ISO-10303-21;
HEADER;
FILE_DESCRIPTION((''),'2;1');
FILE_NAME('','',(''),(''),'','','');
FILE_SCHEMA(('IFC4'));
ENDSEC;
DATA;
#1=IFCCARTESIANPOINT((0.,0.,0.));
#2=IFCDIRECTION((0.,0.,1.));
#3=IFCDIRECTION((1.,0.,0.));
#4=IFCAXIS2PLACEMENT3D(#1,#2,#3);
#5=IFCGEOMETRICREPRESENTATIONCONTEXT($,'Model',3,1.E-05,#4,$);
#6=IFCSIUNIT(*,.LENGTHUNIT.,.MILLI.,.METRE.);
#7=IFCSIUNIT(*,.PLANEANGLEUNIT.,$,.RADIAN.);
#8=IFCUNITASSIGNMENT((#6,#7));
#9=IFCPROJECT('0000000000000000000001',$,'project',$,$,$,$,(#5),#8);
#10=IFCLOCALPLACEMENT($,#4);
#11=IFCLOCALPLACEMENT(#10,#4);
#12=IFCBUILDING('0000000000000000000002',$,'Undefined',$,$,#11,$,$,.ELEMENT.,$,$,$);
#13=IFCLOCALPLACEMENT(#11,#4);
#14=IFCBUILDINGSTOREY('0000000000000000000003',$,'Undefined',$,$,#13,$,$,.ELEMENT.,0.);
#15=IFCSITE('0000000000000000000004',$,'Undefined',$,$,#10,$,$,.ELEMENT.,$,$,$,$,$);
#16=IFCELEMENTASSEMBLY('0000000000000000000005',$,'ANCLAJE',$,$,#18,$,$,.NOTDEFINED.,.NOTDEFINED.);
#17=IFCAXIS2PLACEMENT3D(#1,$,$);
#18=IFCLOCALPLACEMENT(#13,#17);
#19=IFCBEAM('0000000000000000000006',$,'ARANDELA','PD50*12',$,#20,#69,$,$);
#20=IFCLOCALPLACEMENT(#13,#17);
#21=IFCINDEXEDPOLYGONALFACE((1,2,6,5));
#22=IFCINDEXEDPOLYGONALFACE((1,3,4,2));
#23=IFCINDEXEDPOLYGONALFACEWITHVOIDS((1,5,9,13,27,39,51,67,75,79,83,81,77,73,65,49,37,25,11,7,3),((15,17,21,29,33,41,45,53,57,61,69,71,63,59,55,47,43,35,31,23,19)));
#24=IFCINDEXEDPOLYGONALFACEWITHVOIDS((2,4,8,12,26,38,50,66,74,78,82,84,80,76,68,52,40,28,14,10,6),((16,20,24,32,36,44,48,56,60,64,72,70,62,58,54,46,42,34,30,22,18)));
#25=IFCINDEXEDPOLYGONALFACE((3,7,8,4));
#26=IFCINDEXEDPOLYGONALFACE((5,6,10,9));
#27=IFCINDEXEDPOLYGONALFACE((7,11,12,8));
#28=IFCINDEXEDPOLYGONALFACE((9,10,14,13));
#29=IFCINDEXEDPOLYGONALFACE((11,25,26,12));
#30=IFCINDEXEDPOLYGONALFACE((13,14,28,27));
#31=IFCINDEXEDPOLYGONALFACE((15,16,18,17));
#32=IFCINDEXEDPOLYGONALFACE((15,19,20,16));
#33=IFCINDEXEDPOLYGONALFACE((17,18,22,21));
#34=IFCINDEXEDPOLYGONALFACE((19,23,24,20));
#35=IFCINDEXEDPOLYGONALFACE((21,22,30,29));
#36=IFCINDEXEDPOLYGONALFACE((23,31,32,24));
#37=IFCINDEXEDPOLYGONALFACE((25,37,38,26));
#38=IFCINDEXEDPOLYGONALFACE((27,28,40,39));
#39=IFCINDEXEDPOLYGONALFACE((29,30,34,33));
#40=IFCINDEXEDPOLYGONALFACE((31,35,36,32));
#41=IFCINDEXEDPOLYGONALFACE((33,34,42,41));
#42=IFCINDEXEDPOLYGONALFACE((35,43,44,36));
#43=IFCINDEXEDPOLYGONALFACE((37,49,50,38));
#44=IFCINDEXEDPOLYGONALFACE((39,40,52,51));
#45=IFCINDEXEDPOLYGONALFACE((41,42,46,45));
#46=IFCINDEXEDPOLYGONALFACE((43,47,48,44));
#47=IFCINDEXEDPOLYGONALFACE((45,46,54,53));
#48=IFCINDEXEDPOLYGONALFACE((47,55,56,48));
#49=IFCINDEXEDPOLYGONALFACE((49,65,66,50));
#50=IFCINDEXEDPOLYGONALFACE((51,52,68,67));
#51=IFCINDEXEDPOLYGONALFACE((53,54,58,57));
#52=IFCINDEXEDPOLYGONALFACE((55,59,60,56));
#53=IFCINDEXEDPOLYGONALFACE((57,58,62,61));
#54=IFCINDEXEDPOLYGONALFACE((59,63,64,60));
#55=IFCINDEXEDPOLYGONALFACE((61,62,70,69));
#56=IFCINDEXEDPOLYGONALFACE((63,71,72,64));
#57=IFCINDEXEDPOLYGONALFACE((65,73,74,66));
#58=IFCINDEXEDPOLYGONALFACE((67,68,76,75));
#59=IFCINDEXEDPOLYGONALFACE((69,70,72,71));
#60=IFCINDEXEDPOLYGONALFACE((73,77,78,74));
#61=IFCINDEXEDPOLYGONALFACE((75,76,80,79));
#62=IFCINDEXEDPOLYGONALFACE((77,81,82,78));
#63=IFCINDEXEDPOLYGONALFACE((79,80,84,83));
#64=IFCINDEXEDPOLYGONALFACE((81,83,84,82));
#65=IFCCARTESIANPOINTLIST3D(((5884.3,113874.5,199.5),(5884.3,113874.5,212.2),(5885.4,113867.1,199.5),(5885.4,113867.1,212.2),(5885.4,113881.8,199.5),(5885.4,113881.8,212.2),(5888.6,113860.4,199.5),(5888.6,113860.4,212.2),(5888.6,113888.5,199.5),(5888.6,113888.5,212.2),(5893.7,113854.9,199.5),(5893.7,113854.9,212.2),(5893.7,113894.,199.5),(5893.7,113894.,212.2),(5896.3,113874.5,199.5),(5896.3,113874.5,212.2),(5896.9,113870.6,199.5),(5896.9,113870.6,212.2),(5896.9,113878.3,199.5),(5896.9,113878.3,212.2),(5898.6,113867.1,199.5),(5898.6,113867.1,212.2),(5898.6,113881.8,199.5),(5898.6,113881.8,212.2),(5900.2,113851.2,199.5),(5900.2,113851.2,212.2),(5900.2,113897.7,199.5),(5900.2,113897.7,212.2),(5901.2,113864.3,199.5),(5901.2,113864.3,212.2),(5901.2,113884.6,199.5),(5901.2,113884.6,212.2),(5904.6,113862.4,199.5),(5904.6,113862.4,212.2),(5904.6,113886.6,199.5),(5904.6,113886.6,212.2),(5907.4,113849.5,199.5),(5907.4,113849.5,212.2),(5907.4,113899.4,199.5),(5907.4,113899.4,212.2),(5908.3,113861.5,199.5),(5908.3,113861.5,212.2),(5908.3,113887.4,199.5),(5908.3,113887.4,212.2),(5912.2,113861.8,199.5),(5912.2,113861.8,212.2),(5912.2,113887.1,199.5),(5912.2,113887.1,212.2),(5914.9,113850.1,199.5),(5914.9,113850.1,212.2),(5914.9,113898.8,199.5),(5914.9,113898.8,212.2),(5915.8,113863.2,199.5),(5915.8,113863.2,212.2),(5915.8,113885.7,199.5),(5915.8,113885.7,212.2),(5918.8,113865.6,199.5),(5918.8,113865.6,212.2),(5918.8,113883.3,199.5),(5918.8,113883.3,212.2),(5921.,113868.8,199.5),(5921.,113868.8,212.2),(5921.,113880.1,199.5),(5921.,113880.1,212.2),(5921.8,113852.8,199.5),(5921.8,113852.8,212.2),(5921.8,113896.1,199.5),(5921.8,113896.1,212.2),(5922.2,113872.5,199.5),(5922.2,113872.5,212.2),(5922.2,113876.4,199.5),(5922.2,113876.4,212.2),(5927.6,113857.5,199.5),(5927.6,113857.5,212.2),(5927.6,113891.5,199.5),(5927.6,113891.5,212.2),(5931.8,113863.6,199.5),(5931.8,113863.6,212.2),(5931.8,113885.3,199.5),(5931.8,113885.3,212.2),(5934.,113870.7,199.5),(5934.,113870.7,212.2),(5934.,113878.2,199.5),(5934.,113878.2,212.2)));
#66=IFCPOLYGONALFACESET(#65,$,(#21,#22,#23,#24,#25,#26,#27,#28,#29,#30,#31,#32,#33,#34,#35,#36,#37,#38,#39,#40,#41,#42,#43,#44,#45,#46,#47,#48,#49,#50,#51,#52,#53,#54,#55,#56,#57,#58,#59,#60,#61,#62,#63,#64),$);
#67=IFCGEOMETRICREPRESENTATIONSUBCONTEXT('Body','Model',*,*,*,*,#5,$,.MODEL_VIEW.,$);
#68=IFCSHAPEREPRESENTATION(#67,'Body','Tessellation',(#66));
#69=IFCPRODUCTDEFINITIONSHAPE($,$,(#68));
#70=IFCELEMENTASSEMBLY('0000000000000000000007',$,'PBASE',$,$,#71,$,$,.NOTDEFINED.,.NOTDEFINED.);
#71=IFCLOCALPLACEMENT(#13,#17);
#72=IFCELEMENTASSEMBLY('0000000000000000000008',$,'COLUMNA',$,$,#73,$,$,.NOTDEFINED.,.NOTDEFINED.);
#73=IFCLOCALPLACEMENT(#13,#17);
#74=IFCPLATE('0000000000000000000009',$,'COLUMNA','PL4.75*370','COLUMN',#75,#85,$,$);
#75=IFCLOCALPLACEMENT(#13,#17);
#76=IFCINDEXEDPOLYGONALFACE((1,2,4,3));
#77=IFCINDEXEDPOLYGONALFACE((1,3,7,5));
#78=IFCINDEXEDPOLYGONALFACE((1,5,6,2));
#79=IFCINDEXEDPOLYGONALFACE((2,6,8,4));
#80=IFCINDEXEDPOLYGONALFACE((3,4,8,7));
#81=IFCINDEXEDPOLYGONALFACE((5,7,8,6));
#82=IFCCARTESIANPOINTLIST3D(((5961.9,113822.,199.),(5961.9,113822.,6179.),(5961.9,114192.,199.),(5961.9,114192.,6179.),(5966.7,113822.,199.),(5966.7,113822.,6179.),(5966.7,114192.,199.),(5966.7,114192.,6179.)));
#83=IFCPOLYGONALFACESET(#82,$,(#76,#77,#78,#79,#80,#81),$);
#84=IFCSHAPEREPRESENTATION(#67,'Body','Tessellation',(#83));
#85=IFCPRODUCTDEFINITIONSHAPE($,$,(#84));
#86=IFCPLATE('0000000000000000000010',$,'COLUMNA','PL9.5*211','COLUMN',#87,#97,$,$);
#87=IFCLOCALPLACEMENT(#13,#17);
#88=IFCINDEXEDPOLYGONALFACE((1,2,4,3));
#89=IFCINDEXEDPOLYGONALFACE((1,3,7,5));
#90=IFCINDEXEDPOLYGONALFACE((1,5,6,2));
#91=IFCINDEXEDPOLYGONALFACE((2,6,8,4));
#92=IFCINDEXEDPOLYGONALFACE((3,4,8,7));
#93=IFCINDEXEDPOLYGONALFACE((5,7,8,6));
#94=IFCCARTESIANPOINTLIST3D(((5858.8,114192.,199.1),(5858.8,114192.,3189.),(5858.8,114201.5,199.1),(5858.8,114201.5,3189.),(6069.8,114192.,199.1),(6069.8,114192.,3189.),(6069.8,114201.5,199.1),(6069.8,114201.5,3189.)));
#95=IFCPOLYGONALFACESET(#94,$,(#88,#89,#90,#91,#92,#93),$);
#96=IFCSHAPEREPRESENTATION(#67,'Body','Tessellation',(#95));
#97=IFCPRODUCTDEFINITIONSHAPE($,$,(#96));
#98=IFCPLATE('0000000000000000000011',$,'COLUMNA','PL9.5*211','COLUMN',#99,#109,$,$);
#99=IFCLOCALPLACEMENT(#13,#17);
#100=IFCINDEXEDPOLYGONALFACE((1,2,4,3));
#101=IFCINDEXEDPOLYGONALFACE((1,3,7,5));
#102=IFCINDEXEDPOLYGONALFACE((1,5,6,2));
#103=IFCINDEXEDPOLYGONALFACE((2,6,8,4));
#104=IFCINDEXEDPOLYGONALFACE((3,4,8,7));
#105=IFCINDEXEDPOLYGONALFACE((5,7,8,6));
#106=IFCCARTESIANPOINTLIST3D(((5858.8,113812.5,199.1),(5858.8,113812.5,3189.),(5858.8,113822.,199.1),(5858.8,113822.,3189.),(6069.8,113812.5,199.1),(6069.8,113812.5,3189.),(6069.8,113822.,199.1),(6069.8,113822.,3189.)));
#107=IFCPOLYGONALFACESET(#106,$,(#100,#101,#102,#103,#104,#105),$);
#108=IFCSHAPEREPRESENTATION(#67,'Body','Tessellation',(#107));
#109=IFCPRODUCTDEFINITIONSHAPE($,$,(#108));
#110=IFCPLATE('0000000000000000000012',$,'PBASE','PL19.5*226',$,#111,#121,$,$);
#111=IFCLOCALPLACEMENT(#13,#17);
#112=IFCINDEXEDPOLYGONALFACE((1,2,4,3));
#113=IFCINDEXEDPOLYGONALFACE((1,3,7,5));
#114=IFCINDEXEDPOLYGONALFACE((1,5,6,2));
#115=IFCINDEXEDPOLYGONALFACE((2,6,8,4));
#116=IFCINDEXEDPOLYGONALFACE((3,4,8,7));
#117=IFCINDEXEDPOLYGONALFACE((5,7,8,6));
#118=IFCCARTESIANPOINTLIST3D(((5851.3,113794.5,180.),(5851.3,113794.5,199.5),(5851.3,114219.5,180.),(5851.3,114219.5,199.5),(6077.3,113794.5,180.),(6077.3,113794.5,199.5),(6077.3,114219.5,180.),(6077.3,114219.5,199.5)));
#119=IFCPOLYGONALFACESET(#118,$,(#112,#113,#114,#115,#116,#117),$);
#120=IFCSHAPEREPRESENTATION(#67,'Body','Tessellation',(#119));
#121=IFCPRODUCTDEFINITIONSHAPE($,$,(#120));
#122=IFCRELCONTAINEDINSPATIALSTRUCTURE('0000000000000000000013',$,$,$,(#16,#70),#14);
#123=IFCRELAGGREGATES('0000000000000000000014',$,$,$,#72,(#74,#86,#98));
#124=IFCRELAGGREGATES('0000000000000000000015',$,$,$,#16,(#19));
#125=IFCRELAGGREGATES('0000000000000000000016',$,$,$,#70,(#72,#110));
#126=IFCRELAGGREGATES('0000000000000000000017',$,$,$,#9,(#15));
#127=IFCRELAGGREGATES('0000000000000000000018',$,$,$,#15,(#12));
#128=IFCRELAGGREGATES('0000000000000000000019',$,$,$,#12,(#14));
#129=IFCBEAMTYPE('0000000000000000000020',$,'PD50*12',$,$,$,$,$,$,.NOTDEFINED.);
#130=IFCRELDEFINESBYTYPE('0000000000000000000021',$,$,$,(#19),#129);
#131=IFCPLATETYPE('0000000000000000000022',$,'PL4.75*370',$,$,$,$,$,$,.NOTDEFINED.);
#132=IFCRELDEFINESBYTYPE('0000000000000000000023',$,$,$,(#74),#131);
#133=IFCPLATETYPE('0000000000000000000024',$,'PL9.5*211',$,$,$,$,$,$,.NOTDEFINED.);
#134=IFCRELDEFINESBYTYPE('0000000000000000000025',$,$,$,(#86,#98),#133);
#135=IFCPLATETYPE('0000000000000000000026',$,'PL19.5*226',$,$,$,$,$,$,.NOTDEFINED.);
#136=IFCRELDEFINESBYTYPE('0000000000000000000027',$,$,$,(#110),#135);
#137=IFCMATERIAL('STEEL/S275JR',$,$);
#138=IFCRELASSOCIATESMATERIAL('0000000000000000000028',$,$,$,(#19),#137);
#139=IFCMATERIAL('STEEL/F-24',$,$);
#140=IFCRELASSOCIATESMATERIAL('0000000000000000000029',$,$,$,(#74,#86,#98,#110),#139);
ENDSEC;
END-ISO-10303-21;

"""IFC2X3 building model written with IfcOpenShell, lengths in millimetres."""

from ifc_helpers import new_model, si_unit, frame, origin_with_axes, origin_2d_with_axis, place, context, subcontext, project, spatial, polyline, hollow_circle, outline, extrude, material, type_object, element, aggregate, save


model = new_model("IFC2X3")

# Units and contexts
model_context = context("Model", 3, precision=1e-05, world=origin_with_axes())
body_context = subcontext(model_context, "Body", "Model", "MODEL_VIEW")
ifc_project = project(units=[si_unit("LENGTHUNIT", "METRE", prefix="MILLI"), si_unit("PLANEANGLEUNIT", "RADIAN")], contexts=[model_context])

# Site, building, storey
site_placement = place(None, origin_with_axes())
site = spatial("IfcSite", under=ifc_project, at=site_placement, Name="Undefined", CompositionType="ELEMENT")
building_placement = place(site_placement, origin_with_axes())
building = spatial("IfcBuilding", under=site, at=building_placement, Name="Undefined", CompositionType="ELEMENT")
storey_placement = place(building_placement, origin_with_axes())
storey = spatial("IfcBuildingStorey", under=building, at=storey_placement, Name="Undefined", CompositionType="ELEMENT", Elevation=0.0)

# Shared definitions
ifc_material_1 = material(Name="STEEL/F-24")

# Element assembly, beam
assembly_1_placement = place(storey_placement, origin_with_axes())
assembly_1 = element("IfcElementAssembly", 1, at=assembly_1_placement, inside=storey, Name="ANCLAJE", AssemblyPlace="NOTDEFINED", PredefinedType="NOTDEFINED")
ifc_material_2 = material(Name="STEEL/S275JR")
beam_type_1 = type_object("IfcBeamType", Name="PD50*12", PredefinedType="NOTDEFINED")
beam_1_placement = place(assembly_1_placement, frame((5909.3, 113874.5, 212.2), z_axis=(0.0, -1.0, 0.0), x_axis=(0.0, 0.0, -1.0)))
beam_1 = element("IfcBeam", 2, at=beam_1_placement, type_object=beam_type_1, material=ifc_material_2, Name="ARANDELA", Description="PD50*12", context=body_context, shape_type="SweptSolid", body=[
    extrude(hollow_circle(Radius=25.0, WallThickness=12.0, at=origin_2d_with_axis()), frame((12.7, 0.0, 0.0), z_axis=(-1.0, 0.0, 0.0), x_axis=(0.0, -1.0, 0.0)), (0.0, 0.0, 1.0), 12.7),
])

# Element assemblies, plates
assembly_2_placement = place(storey_placement, origin_with_axes())
assembly_2 = element("IfcElementAssembly", 3, at=assembly_2_placement, inside=storey, Name="PBASE", AssemblyPlace="NOTDEFINED", PredefinedType="NOTDEFINED")
assembly_3_placement = place(assembly_2_placement, origin_with_axes())
assembly_3 = element("IfcElementAssembly", 4, at=assembly_3_placement, Name="COLUMNA", AssemblyPlace="NOTDEFINED", PredefinedType="NOTDEFINED")
plate_type_1 = type_object("IfcPlateType", Name="PL4.75*370", PredefinedType="NOTDEFINED")
plate_1_placement = place(assembly_3_placement, frame((5964.3, 114007.0, 199.1), z_axis=(-1.0, 0.0, 0.0), x_axis=(0.0, 0.0, 1.0)))
plate_1 = element("IfcPlate", 5, at=plate_1_placement, type_object=plate_type_1, material=ifc_material_1, Name="COLUMNA", Description="PL4.75*370", ObjectType="COLUMN", context=body_context, shape_type="SweptSolid", body=[
    extrude(outline(polyline([(0.0, -185.0), (0.0, 185.0), (5980.0, 185.0), (5980.0, -185.0), (0.0, -185.0)])), frame((0.0, 0.0, -2.4), z_axis=(0.0, 0.0, 1.0), x_axis=(1.0, 0.0, 0.0)), (0.0, 0.0, 1.0), 4.8),
])
plate_type_2 = type_object("IfcPlateType", Name="PL9.5*211", PredefinedType="NOTDEFINED")
plate_2_placement = place(assembly_3_placement, frame((5964.3, 114196.7, 199.1), z_axis=(0.0, -1.0, 0.0), x_axis=(0.0, 0.0, 1.0)))
plate_2 = element("IfcPlate", 6, at=plate_2_placement, type_object=plate_type_2, material=ifc_material_1, Name="COLUMNA", Description="PL9.5*211", ObjectType="COLUMN", context=body_context, shape_type="SweptSolid", body=[
    extrude(outline(polyline([(0.0, -105.5), (0.0, 105.5), (2990.0, 105.5), (2990.0, -105.5), (0.0, -105.5)])), frame((0.0, 0.0, -4.8), z_axis=(0.0, 0.0, 1.0), x_axis=(1.0, 0.0, 0.0)), (0.0, 0.0, 1.0), 9.5),
])
plate_3_placement = place(assembly_3_placement, frame((5964.3, 113817.2, 199.1), z_axis=(0.0, -1.0, 0.0), x_axis=(0.0, 0.0, 1.0)))
plate_3 = element("IfcPlate", 7, at=plate_3_placement, type_object=plate_type_2, material=ifc_material_1, Name="COLUMNA", Description="PL9.5*211", ObjectType="COLUMN", context=body_context, shape_type="SweptSolid", body=[
    extrude(outline(polyline([(0.0, -105.5), (0.0, 105.5), (2990.0, 105.5), (2990.0, -105.5), (0.0, -105.5)])), frame((0.0, 0.0, -4.8), z_axis=(0.0, 0.0, 1.0), x_axis=(1.0, 0.0, 0.0)), (0.0, 0.0, 1.0), 9.5),
])
aggregate(assembly_3, [plate_1, plate_2, plate_3])
plate_type_3 = type_object("IfcPlateType", Name="PL19.5*226", PredefinedType="NOTDEFINED")
plate_4_placement = place(assembly_2_placement, frame((5964.3, 114219.5, 189.8), z_axis=(0.0, 0.0, 1.0), x_axis=(0.0, -1.0, 0.0)))
plate_4 = element("IfcPlate", 8, at=plate_4_placement, type_object=plate_type_3, material=ifc_material_1, Name="PBASE", Description="PL19.5*226", context=body_context, shape_type="SweptSolid", body=[
    extrude(outline(polyline([(0.0, -113.0), (0.0, 113.0), (425.0, 113.0), (425.0, -113.0), (0.0, -113.0)])), frame((0.0, 0.0, -9.8), z_axis=(0.0, 0.0, 1.0), x_axis=(1.0, 0.0, 0.0)), (0.0, 0.0, 1.0), 19.5),
])

aggregate(assembly_1, [beam_1])
aggregate(assembly_2, [assembly_3, plate_4])

save(model, "model.ifc")
